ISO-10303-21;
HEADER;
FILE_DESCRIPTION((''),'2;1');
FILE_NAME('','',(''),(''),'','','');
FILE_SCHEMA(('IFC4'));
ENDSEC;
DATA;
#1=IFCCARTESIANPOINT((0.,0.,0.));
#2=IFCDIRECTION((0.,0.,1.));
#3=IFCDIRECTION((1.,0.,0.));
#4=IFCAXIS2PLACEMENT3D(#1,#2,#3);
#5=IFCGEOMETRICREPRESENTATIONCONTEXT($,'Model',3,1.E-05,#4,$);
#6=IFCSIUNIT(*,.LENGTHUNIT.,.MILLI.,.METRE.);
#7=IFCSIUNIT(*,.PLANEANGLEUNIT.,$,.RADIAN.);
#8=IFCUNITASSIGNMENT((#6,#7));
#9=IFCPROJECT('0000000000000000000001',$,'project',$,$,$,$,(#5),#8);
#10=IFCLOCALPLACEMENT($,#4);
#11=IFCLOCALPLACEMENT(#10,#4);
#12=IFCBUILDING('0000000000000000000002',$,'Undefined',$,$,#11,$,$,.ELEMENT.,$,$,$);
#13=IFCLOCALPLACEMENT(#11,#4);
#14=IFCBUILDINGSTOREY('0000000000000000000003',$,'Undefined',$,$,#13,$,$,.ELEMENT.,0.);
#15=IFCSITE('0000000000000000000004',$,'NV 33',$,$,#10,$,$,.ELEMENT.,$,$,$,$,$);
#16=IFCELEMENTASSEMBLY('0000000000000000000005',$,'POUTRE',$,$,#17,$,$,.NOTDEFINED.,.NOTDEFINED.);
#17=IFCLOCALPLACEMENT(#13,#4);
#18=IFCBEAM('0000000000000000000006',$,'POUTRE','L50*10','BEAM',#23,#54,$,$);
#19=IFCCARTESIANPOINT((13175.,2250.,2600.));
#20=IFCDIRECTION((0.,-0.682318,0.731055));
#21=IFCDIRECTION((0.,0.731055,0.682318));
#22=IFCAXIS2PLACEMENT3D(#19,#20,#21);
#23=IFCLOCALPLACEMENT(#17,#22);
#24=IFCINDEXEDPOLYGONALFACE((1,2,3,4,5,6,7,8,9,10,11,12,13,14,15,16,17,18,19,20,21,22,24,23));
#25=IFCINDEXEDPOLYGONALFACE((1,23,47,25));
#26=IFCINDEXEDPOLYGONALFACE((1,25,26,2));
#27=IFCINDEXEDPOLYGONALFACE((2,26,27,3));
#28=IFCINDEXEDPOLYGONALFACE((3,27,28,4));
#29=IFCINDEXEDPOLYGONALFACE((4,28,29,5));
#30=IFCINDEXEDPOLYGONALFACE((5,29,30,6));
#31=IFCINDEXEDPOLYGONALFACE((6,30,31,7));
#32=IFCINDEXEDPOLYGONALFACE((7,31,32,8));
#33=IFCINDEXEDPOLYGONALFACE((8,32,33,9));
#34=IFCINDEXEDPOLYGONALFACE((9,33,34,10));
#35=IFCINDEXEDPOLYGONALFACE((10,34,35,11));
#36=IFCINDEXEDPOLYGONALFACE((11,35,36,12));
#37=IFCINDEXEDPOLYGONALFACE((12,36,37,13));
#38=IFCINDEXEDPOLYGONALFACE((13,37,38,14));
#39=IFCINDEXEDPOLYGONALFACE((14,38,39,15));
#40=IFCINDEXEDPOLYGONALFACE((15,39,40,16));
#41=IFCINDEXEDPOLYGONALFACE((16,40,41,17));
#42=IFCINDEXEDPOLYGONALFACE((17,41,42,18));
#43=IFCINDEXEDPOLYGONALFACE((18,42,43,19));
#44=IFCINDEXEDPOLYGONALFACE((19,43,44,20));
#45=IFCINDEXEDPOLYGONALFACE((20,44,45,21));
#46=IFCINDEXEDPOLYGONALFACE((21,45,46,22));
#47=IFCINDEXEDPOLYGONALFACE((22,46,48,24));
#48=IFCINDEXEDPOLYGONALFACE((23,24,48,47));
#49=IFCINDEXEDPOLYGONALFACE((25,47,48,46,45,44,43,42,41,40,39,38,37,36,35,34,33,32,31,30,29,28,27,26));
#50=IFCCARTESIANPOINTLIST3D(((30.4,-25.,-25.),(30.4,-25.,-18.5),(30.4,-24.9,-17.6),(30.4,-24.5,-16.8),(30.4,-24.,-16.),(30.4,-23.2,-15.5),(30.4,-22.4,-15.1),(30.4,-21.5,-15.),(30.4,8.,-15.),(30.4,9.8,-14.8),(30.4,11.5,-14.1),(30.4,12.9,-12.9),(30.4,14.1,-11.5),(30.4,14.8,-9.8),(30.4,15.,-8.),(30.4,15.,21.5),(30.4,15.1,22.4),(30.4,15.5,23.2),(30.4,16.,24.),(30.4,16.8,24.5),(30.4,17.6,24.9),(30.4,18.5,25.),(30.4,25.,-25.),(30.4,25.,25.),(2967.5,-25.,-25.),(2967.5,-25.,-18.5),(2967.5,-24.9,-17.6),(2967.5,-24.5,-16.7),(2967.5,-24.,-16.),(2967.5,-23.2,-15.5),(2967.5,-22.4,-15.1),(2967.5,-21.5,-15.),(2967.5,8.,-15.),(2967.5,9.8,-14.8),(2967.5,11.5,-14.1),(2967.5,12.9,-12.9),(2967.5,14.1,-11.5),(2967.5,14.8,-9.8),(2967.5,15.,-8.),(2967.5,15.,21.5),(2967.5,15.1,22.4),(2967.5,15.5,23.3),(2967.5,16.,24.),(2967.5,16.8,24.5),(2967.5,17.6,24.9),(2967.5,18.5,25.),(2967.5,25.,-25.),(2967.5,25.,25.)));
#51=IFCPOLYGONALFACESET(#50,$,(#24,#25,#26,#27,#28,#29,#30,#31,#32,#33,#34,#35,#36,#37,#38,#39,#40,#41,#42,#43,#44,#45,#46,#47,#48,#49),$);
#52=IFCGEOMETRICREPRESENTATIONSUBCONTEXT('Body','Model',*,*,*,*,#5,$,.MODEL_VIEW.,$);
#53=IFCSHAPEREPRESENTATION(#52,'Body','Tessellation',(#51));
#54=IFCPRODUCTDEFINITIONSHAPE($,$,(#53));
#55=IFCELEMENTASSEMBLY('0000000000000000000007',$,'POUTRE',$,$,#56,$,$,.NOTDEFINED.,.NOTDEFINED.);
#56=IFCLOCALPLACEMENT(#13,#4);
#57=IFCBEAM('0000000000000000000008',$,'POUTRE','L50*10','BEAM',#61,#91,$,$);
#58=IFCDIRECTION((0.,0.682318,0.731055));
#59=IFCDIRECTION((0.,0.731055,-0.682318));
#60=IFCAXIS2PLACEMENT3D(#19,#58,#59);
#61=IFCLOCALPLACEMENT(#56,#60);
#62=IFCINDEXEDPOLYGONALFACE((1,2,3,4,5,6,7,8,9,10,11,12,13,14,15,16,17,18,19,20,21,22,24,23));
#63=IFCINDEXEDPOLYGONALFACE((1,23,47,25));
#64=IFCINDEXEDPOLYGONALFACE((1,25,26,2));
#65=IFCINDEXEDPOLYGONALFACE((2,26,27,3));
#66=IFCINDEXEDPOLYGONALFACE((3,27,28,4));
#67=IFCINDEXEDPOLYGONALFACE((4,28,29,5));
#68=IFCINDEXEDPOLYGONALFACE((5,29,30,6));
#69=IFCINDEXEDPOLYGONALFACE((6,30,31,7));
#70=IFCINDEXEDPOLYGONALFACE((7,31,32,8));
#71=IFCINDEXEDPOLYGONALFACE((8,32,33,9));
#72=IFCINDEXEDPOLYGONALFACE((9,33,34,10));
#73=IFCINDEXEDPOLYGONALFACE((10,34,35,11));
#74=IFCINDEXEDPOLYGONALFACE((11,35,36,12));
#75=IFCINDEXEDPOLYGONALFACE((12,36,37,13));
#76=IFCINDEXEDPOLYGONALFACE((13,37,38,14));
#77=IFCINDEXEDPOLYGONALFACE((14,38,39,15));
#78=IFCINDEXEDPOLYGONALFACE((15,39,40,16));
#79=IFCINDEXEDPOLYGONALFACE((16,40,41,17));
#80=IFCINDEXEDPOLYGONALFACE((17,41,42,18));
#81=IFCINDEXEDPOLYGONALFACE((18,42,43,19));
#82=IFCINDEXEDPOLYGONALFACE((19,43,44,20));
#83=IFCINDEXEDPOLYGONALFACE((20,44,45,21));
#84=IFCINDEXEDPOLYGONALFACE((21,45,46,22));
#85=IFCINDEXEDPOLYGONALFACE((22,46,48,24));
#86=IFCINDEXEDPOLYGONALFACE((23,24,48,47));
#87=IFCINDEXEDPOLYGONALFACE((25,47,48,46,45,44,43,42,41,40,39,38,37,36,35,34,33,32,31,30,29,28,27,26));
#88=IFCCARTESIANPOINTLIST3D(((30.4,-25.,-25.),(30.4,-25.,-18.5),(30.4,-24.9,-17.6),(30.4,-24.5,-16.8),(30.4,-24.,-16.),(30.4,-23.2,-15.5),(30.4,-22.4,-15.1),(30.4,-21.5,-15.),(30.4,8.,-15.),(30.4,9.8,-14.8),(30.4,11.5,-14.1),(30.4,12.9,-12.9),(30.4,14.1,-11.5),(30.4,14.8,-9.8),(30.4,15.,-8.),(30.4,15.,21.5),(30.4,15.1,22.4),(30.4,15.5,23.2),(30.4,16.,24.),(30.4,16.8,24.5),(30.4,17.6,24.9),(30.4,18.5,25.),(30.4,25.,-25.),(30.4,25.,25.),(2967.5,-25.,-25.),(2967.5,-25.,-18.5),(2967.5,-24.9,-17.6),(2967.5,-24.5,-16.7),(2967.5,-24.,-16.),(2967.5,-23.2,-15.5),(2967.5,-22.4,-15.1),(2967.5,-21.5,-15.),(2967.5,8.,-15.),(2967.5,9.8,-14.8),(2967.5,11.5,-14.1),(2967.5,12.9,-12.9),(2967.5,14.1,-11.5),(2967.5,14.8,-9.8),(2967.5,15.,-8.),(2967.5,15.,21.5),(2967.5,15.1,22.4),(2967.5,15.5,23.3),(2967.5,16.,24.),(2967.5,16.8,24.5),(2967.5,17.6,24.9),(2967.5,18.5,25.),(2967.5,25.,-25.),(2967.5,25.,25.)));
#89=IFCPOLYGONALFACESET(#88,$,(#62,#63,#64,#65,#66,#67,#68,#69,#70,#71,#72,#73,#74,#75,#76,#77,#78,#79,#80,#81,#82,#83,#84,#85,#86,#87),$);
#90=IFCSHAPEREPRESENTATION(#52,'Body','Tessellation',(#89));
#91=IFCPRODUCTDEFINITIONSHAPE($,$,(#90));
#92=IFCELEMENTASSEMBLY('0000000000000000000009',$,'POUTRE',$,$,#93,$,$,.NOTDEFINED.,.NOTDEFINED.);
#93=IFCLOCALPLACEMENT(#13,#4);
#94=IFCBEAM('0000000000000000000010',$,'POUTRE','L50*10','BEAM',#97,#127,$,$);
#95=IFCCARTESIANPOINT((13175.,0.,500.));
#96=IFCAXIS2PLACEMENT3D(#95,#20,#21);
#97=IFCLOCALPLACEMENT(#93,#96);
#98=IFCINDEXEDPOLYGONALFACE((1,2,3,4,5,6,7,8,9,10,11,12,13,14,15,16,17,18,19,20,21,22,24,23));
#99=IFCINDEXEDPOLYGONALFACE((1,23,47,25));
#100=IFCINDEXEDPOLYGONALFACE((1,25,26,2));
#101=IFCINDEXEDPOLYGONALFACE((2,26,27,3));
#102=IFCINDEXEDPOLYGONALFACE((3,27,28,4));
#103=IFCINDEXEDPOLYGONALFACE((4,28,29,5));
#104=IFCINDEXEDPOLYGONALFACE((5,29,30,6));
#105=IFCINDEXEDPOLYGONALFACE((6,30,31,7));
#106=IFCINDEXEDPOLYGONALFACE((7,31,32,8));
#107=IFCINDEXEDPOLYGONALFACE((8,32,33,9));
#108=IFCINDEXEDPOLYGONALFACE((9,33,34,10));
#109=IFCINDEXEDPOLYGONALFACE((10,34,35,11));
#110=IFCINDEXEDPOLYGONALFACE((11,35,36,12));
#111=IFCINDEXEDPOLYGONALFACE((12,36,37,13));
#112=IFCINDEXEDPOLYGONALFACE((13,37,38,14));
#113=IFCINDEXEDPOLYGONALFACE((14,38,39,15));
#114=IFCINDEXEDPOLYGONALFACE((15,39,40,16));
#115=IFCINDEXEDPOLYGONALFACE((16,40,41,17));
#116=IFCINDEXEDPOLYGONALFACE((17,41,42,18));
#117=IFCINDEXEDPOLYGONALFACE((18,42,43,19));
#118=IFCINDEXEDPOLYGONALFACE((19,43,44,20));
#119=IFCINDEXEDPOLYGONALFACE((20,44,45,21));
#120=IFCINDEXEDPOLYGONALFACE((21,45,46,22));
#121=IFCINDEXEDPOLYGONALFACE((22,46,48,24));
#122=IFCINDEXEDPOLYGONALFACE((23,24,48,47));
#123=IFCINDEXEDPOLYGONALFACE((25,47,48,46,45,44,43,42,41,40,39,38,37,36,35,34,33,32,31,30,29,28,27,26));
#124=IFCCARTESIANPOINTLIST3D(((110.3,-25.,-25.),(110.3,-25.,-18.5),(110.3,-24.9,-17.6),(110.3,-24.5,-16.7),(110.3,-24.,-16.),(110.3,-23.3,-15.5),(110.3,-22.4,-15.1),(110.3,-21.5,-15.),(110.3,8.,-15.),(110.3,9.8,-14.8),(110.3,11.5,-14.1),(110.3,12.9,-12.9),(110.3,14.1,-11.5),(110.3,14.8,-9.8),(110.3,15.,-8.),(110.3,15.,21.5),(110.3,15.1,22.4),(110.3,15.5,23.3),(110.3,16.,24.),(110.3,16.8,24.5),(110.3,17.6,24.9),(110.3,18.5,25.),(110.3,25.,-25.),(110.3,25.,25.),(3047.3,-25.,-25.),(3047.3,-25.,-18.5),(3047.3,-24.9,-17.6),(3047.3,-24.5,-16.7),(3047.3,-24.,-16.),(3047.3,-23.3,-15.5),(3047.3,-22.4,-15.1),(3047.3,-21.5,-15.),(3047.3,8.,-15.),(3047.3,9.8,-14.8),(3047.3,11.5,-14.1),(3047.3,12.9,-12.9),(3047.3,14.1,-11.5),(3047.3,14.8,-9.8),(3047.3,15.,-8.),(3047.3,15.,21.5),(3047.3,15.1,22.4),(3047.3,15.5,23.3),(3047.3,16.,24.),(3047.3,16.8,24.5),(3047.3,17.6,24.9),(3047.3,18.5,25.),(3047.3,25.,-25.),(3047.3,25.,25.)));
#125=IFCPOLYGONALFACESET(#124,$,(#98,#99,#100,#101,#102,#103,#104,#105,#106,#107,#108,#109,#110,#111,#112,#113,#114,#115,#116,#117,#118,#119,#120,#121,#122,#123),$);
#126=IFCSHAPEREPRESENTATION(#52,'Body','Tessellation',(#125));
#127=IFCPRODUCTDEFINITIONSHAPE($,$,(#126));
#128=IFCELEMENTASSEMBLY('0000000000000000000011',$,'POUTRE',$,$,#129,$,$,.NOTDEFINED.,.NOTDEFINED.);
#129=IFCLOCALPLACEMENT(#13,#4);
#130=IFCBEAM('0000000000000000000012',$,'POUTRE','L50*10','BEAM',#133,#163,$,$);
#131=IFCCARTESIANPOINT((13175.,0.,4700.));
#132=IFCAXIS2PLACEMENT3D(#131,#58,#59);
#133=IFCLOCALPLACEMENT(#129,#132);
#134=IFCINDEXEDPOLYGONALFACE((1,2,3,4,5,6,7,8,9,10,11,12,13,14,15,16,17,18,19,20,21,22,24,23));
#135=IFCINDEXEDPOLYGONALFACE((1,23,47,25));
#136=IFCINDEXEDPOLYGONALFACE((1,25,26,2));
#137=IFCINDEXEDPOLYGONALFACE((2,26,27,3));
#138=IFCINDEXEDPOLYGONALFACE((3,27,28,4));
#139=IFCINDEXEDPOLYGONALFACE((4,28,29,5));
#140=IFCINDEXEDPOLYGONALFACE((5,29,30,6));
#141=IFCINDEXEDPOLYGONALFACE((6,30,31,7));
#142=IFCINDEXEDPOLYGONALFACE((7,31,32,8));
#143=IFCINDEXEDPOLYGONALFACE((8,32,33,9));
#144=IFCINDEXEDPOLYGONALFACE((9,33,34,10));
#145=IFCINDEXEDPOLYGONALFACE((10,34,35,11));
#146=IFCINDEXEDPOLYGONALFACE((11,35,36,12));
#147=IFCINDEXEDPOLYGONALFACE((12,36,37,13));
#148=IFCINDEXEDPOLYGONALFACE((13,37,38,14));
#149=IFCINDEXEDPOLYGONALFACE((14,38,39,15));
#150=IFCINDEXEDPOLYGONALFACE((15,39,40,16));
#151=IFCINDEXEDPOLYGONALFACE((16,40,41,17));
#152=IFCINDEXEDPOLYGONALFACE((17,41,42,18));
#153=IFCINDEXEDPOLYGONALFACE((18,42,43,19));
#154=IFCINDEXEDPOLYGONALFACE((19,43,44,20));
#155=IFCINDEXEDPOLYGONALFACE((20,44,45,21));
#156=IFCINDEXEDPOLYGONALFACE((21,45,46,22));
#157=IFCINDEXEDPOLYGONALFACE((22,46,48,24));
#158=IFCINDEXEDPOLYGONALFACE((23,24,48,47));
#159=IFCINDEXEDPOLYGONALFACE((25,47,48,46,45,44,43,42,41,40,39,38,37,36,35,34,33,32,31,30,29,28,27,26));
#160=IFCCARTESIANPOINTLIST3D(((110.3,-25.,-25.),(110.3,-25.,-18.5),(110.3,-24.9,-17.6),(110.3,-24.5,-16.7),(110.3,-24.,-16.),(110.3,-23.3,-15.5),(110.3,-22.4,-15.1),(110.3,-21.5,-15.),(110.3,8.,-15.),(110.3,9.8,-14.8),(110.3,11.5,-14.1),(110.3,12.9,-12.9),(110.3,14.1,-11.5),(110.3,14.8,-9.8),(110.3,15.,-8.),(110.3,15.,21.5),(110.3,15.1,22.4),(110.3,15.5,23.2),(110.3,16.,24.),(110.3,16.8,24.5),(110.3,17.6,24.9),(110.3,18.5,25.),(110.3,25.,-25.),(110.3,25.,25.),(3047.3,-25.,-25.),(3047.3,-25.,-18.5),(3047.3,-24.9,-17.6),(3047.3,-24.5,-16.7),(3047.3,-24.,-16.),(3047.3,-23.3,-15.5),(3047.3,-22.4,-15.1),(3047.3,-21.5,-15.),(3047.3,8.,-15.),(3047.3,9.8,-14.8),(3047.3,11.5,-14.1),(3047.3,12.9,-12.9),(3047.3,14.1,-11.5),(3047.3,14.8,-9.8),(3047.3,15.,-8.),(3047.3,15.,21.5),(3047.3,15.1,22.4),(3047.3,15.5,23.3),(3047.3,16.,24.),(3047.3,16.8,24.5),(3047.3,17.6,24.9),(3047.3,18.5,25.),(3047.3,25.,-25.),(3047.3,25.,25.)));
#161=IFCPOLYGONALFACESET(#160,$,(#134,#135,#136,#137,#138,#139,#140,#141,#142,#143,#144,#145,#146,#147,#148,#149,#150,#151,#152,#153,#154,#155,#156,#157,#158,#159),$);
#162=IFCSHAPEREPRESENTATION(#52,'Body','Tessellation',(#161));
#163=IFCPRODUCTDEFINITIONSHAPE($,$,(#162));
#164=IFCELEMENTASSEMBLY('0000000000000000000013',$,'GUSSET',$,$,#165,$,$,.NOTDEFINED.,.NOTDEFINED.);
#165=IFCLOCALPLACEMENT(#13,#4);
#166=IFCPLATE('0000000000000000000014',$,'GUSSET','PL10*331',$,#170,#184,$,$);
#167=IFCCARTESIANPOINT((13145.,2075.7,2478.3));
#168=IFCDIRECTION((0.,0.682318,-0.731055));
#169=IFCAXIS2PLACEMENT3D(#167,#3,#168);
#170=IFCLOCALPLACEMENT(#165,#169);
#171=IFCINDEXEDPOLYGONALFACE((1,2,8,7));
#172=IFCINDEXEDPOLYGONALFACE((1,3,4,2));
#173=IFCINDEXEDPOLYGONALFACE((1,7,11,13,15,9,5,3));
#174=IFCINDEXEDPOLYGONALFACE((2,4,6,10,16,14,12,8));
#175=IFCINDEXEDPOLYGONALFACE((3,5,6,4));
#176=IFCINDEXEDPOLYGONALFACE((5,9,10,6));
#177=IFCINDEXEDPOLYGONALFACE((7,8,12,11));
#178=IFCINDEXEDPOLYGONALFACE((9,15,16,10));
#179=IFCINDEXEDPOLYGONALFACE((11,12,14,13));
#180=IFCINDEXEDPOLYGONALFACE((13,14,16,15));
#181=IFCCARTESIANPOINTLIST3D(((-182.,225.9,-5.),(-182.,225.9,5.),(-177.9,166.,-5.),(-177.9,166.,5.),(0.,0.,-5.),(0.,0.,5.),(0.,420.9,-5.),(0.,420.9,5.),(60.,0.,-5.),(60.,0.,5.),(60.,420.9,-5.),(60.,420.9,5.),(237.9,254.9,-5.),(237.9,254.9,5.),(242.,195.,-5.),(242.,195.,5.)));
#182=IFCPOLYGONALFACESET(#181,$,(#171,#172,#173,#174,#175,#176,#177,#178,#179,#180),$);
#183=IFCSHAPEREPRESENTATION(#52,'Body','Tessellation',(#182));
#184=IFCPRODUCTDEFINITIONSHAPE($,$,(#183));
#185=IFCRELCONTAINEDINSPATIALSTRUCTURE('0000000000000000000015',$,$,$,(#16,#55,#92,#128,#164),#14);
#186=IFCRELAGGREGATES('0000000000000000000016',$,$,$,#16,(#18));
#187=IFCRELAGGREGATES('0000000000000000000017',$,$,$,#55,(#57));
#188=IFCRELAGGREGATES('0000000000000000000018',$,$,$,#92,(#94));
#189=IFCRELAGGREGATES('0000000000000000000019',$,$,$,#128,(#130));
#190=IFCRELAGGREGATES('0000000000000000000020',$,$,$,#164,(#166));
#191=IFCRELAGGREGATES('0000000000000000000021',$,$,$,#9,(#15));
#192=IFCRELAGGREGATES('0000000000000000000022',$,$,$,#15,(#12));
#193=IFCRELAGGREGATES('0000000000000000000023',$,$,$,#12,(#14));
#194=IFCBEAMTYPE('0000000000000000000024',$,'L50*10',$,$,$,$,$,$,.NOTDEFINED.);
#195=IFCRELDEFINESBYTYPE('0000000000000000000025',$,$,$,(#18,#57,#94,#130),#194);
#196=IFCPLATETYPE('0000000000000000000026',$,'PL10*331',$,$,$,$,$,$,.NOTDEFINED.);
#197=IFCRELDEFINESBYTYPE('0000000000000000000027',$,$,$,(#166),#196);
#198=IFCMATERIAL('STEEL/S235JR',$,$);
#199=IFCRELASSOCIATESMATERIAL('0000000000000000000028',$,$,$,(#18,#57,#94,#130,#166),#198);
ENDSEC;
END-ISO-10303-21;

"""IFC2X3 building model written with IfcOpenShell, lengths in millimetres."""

from ifc_helpers import new_model, si_unit, frame, origin_with_axes, origin_2d_with_axis, place, context, subcontext, project, spatial, polyline, l_section, outline, extrude, clip, halfspace, material, type_object, element, aggregate, save


model = new_model("IFC2X3")

# Units and contexts
model_context = context("Model", 3, precision=1e-05, world=origin_with_axes())
body_context = subcontext(model_context, "Body", "Model", "MODEL_VIEW")
ifc_project = project(units=[si_unit("LENGTHUNIT", "METRE", prefix="MILLI"), si_unit("PLANEANGLEUNIT", "RADIAN")], contexts=[model_context])

# Site, building, storey
site_placement = place(None, origin_with_axes())
site = spatial("IfcSite", under=ifc_project, at=site_placement, Name="NV 33", CompositionType="ELEMENT")
building_placement = place(site_placement, origin_with_axes())
building = spatial("IfcBuilding", under=site, at=building_placement, Name="Undefined", CompositionType="ELEMENT")
storey_placement = place(building_placement, origin_with_axes())
storey = spatial("IfcBuildingStorey", under=building, at=storey_placement, Name="Undefined", CompositionType="ELEMENT", Elevation=0.0)

# Shared definitions
ifc_material_1 = material(Name="STEEL/S235JR")

# Element assemblies, beams
assembly_1_placement = place(storey_placement, origin_with_axes())
assembly_1 = element("IfcElementAssembly", 1, at=assembly_1_placement, inside=storey, Name="POUTRE", AssemblyPlace="NOTDEFINED", PredefinedType="NOTDEFINED")
beam_type_1 = type_object("IfcBeamType", Name="L50*10", PredefinedType="NOTDEFINED")
beam_1_placement = place(assembly_1_placement, frame((13175.0, 2250.0, 2600.0), z_axis=(0.0, -0.682318, 0.731055), x_axis=(0.0, 0.731055, 0.682318)))
beam_1 = element("IfcBeam", 2, at=beam_1_placement, type_object=beam_type_1, material=ifc_material_1, Name="POUTRE", Description="L50*10", ObjectType="BEAM", context=body_context, shape_type="Clipping", body=[
    clip(clip(extrude(l_section(Depth=50.0, Width=50.0, Thickness=10.0, FilletRadius=7.0, EdgeRadius=3.5, at=origin_2d_with_axis()), frame((3077.7, 0.0, 0.0), z_axis=(-1.0, 0.0, 0.0), x_axis=(0.0, -1.0, 0.0)), (0.0, 0.0, 1.0), 3097.7), halfspace(frame((2967.5, 31.0, 0.0), z_axis=(-1.0, 0.0, 0.0), x_axis=(0.0, 0.0, 1.0)), True)), halfspace(frame((30.4, 0.0, 25.0), z_axis=(1.0, 0.0, 0.0), x_axis=(0.0, 1.0, 0.0)), True)),
])
assembly_2_placement = place(storey_placement, origin_with_axes())
assembly_2 = element("IfcElementAssembly", 3, at=assembly_2_placement, inside=storey, Name="POUTRE", AssemblyPlace="NOTDEFINED", PredefinedType="NOTDEFINED")
beam_2_placement = place(assembly_2_placement, frame((13175.0, 2250.0, 2600.0), z_axis=(0.0, 0.682318, 0.731055), x_axis=(0.0, 0.731055, -0.682318)))
beam_2 = element("IfcBeam", 4, at=beam_2_placement, type_object=beam_type_1, material=ifc_material_1, Name="POUTRE", Description="L50*10", ObjectType="BEAM", context=body_context, shape_type="Clipping", body=[
    clip(clip(extrude(l_section(Depth=50.0, Width=50.0, Thickness=10.0, FilletRadius=7.0, EdgeRadius=3.5, at=origin_2d_with_axis()), frame((3077.7, 0.0, 0.0), z_axis=(-1.0, 0.0, 0.0), x_axis=(0.0, -1.0, 0.0)), (0.0, 0.0, 1.0), 3097.7), halfspace(frame((2967.5, 31.0, 0.0), z_axis=(-1.0, 0.0, 0.0), x_axis=(0.0, 0.0, 1.0)), True)), halfspace(frame((30.4, 0.0, 25.0), z_axis=(1.0, 0.0, 0.0), x_axis=(0.0, 1.0, 0.0)), True)),
])
assembly_3_placement = place(storey_placement, origin_with_axes())
assembly_3 = element("IfcElementAssembly", 5, at=assembly_3_placement, inside=storey, Name="POUTRE", AssemblyPlace="NOTDEFINED", PredefinedType="NOTDEFINED")
beam_3_placement = place(assembly_3_placement, frame((13175.0, 0.0, 500.0), z_axis=(0.0, -0.682318, 0.731055), x_axis=(0.0, 0.731055, 0.682318)))
beam_3 = element("IfcBeam", 6, at=beam_3_placement, type_object=beam_type_1, material=ifc_material_1, Name="POUTRE", Description="L50*10", ObjectType="BEAM", context=body_context, shape_type="Clipping", body=[
    clip(clip(extrude(l_section(Depth=50.0, Width=50.0, Thickness=10.0, FilletRadius=7.0, EdgeRadius=3.5, at=origin_2d_with_axis()), frame((3097.7, 0.0, 0.0), z_axis=(-1.0, 0.0, 0.0), x_axis=(0.0, -1.0, 0.0)), (0.0, 0.0, 1.0), 3097.7), halfspace(frame((3047.3, 0.0, -25.0), z_axis=(-1.0, 0.0, 0.0), x_axis=(0.0, 1.0, 0.0)), True)), halfspace(frame((110.3, 31.0, 0.0), z_axis=(1.0, 0.0, 0.0), x_axis=(0.0, 0.0, -1.0)), True)),
])
assembly_4_placement = place(storey_placement, origin_with_axes())
assembly_4 = element("IfcElementAssembly", 7, at=assembly_4_placement, inside=storey, Name="POUTRE", AssemblyPlace="NOTDEFINED", PredefinedType="NOTDEFINED")
beam_4_placement = place(assembly_4_placement, frame((13175.0, 0.0, 4700.0), z_axis=(0.0, 0.682318, 0.731055), x_axis=(0.0, 0.731055, -0.682318)))
beam_4 = element("IfcBeam", 8, at=beam_4_placement, type_object=beam_type_1, material=ifc_material_1, Name="POUTRE", Description="L50*10", ObjectType="BEAM", context=body_context, shape_type="Clipping", body=[
    clip(clip(extrude(l_section(Depth=50.0, Width=50.0, Thickness=10.0, FilletRadius=7.0, EdgeRadius=3.5, at=origin_2d_with_axis()), frame((3097.7, 0.0, 0.0), z_axis=(-1.0, 0.0, 0.0), x_axis=(0.0, -1.0, 0.0)), (0.0, 0.0, 1.0), 3097.7), halfspace(frame((3047.3, 0.0, -25.0), z_axis=(-1.0, 0.0, 0.0), x_axis=(0.0, 1.0, 0.0)), True)), halfspace(frame((110.3, 31.0, 0.0), z_axis=(1.0, 0.0, 0.0), x_axis=(0.0, 0.0, -1.0)), True)),
])

# Element assembly, plate
assembly_5_placement = place(storey_placement, origin_with_axes())
assembly_5 = element("IfcElementAssembly", 9, at=assembly_5_placement, inside=storey, Name="GUSSET", AssemblyPlace="NOTDEFINED", PredefinedType="NOTDEFINED")
plate_type_1 = type_object("IfcPlateType", Name="PL10*331", PredefinedType="NOTDEFINED")
plate_1_placement = place(assembly_5_placement, frame((13145.0, 2075.7, 2478.3), z_axis=(1.0, 0.0, 0.0), x_axis=(0.0, 0.682318, -0.731055)))
plate_1 = element("IfcPlate", 10, at=plate_1_placement, type_object=plate_type_1, material=ifc_material_1, Name="GUSSET", Description="PL10*331", context=body_context, shape_type="SweptSolid", body=[
    extrude(outline(polyline([(0.0, 0.0), (60.0, 0.0), (242.0, 195.0), (237.9, 254.9), (60.0, 420.9), (0.0, 420.9), (-182.0, 225.9), (-177.9, 166.0), (0.0, 0.0)])), frame((0.0, 0.0, -5.0), z_axis=(0.0, 0.0, 1.0), x_axis=(1.0, 0.0, 0.0)), (0.0, 0.0, 1.0), 10.0),
])

aggregate(assembly_1, [beam_1])
aggregate(assembly_2, [beam_2])
aggregate(assembly_3, [beam_3])
aggregate(assembly_4, [beam_4])
aggregate(assembly_5, [plate_1])

save(model, "model.ifc")
